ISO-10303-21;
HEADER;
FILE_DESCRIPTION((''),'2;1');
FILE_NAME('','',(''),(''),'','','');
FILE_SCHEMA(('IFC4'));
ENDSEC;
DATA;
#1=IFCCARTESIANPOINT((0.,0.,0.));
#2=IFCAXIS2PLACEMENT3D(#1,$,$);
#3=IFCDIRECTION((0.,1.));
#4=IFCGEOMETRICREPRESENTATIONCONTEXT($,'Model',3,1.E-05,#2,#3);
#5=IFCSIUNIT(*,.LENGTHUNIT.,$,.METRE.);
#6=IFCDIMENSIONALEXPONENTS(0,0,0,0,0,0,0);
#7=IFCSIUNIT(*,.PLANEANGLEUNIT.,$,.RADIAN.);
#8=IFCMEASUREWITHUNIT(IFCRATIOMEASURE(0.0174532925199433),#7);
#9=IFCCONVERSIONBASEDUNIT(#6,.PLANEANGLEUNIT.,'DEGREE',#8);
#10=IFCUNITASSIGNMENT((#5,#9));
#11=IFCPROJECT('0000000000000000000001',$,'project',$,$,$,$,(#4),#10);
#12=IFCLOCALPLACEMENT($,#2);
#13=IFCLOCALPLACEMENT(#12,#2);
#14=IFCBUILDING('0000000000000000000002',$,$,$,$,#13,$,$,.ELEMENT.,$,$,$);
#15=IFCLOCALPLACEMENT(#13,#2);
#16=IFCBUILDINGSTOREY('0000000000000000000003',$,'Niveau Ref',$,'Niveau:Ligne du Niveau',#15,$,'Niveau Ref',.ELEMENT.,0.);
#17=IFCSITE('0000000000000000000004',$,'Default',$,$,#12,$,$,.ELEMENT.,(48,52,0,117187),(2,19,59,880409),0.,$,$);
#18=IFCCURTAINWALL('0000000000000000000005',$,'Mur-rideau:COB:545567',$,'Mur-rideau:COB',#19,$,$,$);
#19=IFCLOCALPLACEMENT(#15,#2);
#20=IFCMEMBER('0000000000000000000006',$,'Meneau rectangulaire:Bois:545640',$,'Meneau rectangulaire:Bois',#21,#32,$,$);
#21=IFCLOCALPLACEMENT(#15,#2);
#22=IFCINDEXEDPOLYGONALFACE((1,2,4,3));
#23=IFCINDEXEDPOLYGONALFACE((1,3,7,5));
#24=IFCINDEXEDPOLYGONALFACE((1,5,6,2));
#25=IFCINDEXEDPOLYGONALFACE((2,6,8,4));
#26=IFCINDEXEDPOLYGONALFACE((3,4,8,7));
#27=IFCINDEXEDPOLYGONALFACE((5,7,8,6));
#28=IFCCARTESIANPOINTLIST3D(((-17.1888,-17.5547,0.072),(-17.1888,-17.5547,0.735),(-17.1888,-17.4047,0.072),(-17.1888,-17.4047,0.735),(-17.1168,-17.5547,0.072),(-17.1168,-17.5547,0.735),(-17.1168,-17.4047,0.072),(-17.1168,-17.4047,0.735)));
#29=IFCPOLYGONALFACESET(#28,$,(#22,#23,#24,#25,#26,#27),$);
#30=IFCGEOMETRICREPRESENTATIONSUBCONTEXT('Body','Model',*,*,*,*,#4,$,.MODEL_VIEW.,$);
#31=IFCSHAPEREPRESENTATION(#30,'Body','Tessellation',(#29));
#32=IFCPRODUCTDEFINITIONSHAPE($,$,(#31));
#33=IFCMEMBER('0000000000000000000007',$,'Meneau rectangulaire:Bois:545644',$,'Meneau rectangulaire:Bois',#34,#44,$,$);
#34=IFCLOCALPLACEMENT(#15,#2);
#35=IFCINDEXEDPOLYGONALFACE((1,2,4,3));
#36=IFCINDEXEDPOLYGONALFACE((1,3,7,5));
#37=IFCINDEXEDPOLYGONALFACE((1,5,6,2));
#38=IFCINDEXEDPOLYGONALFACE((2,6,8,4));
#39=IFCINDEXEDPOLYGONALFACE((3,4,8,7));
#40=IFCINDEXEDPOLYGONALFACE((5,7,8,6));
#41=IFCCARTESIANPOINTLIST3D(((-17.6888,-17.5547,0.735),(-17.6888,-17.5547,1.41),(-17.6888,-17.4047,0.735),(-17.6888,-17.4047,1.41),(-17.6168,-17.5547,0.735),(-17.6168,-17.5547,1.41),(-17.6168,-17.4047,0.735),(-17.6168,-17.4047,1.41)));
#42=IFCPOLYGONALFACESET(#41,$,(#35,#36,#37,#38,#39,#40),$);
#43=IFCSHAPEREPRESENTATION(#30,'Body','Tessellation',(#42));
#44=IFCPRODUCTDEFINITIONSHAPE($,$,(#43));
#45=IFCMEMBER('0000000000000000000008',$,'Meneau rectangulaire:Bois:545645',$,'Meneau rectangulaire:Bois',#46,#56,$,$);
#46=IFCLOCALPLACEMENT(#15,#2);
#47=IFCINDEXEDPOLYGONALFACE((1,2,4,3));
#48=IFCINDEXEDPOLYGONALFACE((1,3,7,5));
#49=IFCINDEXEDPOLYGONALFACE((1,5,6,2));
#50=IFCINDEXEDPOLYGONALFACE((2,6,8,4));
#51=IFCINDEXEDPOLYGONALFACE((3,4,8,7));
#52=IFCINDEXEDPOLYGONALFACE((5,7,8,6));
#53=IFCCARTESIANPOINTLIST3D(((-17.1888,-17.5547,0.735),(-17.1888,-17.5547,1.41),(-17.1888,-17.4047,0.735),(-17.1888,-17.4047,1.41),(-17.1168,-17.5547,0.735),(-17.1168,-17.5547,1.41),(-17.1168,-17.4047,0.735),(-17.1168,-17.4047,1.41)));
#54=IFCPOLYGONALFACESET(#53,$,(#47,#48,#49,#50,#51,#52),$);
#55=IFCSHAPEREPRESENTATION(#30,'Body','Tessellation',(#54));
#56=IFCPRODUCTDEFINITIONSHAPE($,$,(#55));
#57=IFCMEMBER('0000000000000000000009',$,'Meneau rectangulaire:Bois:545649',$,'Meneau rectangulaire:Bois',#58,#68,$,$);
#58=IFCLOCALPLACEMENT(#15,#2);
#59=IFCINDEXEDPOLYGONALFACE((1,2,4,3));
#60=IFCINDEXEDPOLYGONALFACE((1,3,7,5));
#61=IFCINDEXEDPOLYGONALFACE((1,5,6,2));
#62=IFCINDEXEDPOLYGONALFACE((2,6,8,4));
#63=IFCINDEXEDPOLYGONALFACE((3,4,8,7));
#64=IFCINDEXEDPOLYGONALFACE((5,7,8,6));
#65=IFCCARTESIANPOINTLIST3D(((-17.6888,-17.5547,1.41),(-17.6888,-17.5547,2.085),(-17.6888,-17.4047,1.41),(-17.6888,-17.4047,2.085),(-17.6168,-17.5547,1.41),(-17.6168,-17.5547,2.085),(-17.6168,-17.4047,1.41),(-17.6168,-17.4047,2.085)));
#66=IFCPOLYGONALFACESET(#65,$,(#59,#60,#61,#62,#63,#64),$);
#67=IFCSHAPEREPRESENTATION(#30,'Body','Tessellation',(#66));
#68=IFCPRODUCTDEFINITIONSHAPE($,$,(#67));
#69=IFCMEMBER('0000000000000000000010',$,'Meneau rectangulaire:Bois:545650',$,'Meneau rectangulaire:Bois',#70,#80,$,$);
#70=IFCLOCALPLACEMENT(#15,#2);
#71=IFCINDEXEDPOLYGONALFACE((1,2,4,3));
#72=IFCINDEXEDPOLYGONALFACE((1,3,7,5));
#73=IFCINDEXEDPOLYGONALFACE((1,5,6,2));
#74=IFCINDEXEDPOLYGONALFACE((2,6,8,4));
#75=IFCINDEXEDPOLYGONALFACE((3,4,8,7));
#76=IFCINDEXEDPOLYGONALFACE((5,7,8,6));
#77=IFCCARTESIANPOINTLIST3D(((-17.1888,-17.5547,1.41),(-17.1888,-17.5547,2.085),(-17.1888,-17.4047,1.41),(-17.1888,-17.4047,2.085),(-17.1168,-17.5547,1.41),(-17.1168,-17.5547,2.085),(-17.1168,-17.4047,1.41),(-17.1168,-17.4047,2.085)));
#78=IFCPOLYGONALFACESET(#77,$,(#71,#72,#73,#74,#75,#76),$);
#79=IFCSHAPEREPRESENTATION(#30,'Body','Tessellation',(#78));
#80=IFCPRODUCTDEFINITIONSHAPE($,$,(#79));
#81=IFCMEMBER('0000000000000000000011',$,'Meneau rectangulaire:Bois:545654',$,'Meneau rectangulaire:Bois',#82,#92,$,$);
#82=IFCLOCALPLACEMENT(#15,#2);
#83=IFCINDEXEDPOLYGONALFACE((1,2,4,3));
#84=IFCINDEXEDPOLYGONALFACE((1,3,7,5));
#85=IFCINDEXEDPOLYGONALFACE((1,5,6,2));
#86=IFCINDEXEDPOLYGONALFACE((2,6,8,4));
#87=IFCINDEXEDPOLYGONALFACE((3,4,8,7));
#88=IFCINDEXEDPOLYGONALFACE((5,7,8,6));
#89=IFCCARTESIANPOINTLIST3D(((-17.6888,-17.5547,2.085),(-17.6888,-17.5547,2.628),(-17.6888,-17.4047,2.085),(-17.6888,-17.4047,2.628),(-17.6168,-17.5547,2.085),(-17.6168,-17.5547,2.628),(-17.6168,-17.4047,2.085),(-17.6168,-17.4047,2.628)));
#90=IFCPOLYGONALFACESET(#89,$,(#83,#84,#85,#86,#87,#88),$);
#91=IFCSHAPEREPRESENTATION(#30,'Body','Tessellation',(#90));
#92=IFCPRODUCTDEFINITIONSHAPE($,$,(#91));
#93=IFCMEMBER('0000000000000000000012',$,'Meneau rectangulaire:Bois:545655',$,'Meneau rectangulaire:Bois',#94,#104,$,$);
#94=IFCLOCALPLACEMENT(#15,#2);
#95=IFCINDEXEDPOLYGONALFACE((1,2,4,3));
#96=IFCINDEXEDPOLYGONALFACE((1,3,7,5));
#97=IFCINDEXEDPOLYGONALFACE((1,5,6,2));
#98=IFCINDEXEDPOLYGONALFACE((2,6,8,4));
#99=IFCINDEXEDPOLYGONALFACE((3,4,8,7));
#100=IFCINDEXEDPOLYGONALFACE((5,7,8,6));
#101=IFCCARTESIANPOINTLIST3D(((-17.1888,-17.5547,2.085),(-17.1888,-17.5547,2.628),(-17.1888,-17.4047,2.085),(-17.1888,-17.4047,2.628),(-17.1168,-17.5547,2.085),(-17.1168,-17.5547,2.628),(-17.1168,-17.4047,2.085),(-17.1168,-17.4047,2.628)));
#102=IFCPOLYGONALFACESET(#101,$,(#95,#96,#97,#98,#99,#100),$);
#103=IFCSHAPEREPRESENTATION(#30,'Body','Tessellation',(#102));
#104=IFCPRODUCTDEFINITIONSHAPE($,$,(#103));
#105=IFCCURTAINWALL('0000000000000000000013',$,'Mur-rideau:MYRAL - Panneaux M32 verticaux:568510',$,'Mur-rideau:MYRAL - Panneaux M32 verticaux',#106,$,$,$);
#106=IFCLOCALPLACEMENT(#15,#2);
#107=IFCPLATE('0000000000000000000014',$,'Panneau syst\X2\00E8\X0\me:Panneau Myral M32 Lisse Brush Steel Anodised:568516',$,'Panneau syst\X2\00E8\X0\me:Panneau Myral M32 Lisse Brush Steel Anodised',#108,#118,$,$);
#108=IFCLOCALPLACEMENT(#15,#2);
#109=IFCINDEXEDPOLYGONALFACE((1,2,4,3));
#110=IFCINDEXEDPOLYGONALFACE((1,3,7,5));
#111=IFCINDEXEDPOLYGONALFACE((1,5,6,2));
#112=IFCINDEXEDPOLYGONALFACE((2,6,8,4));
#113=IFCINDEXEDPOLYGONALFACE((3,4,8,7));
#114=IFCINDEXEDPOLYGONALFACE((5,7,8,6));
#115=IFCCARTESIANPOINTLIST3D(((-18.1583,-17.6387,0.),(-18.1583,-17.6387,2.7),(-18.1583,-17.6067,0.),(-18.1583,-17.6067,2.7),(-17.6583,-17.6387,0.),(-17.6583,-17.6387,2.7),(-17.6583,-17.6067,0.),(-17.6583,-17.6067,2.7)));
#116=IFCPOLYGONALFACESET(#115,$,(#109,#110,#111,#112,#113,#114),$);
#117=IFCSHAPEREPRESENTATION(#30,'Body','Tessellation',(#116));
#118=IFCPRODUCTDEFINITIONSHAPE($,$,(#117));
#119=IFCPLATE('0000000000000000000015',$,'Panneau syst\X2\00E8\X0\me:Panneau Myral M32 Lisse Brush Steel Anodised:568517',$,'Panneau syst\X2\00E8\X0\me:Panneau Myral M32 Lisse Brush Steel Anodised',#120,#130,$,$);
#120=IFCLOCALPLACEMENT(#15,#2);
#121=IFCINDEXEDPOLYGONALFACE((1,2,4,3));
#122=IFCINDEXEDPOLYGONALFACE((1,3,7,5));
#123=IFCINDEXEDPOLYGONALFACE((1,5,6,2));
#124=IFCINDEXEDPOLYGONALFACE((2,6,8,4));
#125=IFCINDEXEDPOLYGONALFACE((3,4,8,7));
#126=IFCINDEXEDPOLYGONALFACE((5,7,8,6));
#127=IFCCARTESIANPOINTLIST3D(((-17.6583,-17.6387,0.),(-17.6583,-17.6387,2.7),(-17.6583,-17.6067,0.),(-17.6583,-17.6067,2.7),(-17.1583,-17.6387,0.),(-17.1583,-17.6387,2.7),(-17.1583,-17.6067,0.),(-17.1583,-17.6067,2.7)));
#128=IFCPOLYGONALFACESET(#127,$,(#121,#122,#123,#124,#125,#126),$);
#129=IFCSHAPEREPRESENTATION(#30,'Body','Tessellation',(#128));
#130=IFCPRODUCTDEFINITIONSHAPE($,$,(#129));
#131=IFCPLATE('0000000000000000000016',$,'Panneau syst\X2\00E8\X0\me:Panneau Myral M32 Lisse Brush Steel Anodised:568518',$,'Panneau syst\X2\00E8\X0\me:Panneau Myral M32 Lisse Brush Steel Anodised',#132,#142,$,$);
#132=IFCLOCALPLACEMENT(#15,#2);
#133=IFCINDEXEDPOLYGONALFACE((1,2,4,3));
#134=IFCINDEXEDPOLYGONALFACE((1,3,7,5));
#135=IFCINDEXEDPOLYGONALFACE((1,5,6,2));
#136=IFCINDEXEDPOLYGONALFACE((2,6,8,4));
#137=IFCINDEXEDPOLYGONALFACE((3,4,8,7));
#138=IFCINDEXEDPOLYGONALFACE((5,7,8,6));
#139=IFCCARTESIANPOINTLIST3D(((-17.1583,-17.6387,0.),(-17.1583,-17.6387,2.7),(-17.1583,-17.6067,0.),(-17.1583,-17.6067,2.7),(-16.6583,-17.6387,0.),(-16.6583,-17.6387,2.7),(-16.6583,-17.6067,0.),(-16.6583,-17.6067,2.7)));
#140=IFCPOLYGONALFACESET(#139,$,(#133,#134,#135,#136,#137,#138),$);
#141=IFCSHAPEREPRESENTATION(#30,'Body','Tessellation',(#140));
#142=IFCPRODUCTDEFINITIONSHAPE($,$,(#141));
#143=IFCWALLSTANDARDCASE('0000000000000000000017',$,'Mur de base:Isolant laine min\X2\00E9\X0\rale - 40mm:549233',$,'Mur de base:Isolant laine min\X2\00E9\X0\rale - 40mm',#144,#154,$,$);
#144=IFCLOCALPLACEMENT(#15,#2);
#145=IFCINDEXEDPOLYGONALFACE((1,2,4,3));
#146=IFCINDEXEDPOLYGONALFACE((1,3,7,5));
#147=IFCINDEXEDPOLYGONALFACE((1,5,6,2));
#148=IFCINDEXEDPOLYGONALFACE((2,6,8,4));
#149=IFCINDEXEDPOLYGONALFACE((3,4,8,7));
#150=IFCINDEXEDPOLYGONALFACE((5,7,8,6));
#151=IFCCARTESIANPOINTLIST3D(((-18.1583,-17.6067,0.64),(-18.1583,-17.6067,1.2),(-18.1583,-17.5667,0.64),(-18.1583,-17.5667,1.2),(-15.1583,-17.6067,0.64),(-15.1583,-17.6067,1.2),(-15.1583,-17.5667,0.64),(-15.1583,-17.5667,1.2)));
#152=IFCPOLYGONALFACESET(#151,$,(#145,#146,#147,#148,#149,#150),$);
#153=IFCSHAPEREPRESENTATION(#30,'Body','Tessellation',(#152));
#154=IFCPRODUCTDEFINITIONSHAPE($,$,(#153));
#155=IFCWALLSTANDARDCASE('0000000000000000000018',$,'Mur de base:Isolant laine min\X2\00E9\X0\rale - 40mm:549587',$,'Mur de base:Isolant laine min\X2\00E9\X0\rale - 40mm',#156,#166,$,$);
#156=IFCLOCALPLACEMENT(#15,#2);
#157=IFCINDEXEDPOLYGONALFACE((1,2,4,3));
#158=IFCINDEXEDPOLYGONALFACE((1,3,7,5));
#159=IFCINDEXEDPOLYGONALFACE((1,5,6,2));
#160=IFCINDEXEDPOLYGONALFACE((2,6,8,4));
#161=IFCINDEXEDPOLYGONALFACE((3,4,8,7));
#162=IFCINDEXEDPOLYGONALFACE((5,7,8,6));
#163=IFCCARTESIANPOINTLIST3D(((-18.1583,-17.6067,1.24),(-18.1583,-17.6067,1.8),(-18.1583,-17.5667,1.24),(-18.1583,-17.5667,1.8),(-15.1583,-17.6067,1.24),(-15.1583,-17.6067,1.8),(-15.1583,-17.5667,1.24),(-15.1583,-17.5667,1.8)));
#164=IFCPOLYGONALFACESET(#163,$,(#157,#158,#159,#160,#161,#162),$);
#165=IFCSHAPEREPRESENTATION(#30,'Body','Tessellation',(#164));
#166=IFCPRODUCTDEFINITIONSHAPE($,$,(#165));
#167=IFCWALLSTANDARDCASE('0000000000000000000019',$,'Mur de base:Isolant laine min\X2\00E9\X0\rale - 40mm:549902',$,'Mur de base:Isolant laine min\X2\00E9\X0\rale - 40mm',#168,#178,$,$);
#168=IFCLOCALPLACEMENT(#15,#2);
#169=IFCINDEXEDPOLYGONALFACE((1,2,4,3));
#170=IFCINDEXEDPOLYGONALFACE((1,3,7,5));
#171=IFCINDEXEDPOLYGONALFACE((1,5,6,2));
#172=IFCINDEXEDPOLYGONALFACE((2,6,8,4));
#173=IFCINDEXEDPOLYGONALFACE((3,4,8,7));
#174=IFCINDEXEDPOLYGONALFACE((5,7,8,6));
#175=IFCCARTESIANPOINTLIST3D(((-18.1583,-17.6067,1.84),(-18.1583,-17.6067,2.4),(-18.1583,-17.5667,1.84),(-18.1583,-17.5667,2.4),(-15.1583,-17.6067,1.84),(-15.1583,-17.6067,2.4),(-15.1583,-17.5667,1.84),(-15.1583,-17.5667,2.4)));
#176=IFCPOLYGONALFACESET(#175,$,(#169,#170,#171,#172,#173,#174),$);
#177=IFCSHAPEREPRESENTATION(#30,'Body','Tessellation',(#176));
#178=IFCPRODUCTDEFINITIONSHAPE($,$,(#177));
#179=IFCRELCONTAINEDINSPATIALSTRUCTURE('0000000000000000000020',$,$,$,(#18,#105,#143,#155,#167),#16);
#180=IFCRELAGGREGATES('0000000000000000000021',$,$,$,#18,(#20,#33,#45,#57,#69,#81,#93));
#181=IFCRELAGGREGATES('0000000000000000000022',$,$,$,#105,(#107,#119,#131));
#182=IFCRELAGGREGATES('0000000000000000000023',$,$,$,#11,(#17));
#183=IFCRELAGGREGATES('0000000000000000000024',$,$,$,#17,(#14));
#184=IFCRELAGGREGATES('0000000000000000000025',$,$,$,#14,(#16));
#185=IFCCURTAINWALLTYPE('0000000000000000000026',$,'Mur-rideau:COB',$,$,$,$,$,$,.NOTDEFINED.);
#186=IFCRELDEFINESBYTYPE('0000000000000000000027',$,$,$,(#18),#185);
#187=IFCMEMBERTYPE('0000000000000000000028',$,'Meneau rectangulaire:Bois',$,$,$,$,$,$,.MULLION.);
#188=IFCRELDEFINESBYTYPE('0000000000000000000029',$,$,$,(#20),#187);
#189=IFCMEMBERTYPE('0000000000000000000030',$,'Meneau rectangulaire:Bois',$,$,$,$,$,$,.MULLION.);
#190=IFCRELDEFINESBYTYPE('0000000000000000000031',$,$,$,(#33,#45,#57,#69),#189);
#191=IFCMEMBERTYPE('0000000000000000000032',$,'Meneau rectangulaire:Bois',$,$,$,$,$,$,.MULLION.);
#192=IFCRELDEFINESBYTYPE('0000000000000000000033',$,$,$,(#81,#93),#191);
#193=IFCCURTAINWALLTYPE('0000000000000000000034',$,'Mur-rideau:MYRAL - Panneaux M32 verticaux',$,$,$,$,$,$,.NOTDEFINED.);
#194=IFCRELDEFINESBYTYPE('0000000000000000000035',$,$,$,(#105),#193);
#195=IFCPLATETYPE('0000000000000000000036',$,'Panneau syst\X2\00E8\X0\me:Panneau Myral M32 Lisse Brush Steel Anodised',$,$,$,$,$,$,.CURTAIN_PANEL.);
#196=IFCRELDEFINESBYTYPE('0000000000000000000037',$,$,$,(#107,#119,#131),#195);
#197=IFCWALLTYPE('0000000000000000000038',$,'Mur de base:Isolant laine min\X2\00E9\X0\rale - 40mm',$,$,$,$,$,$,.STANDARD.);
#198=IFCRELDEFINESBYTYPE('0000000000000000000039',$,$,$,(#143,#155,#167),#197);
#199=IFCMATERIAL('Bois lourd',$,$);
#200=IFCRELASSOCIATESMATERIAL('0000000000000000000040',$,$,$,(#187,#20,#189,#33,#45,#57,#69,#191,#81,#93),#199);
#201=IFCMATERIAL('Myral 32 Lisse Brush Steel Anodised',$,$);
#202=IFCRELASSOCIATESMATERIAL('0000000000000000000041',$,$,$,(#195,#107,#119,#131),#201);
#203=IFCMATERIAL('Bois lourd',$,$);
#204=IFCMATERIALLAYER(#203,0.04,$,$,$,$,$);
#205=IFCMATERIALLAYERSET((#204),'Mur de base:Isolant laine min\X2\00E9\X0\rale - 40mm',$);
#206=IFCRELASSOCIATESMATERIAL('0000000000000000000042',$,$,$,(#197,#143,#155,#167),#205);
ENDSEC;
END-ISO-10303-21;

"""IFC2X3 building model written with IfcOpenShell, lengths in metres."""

from ifc_helpers import new_model, entity, si_unit, converted_unit, direction, frame, frame_2d, origin, origin_2d_with_axis, place, context, subcontext, project, spatial, rectangle, extrude, source, transform, mapped, material, layer, layer_set, layer_usage, type_object, type_shapes, element, aggregate, save


model = new_model("IFC2X3")

# Units and contexts
model_context = context("Model", 3, precision=1e-05, world=origin(), true_north=direction((0.0, 1.0)))
body_context = subcontext(model_context, "Body", "Model", "MODEL_VIEW")
ifc_project = project(units=[si_unit("LENGTHUNIT", "METRE"), converted_unit("PLANEANGLEUNIT", "DEGREE", entity("IfcRatioMeasure", 0.0174532925199433), si_unit("PLANEANGLEUNIT", "RADIAN"), dimensions=[0, 0, 0, 0, 0, 0, 0])], contexts=[model_context])

# Site, building, storey
site_placement = place(None, origin())
site = spatial("IfcSite", under=ifc_project, at=site_placement, Name="Default", CompositionType="ELEMENT", RefLatitude=(48, 52, 0, 117187), RefLongitude=(2, 19, 59, 880409), RefElevation=0.0)
building_placement = place(site_placement, origin())
building = spatial("IfcBuilding", under=site, at=building_placement, CompositionType="ELEMENT")
storey_placement = place(building_placement, origin())
storey = spatial("IfcBuildingStorey", under=building, at=storey_placement, Name="Niveau Ref", ObjectType="Niveau:Ligne du Niveau", LongName="Niveau Ref", CompositionType="ELEMENT", Elevation=0.0)

# Curtain wall, members
curtain_wall_type_1 = type_object("IfcCurtainWallType", Name="Mur-rideau:COB", PredefinedType="NOTDEFINED")
curtain_wall_1_placement = place(storey_placement, origin())
curtain_wall_1 = element("IfcCurtainWall", 1, at=curtain_wall_1_placement, inside=storey, type_object=curtain_wall_type_1, Name="Mur-rideau:COB:545567", ObjectType="Mur-rideau:COB")
ifc_material_1 = material(Name="Bois lourd")
member_type_1 = type_object("IfcMemberType", Name="Meneau rectangulaire:Bois", PredefinedType="MULLION", material=ifc_material_1)
shared_shape_1 = source(origin(), body_context, "Body", "SweptSolid", [
    extrude(rectangle(XDim=0.15, YDim=0.072, at=origin_2d_with_axis()), frame((-0.024, 0.0, -0.663), z_axis=(0.0, 0.0, 1.0), x_axis=(0.0, -1.0, 0.0)), (0.0, 0.0, 1.0), 0.663),
])
type_shapes(member_type_1, [shared_shape_1])
member_1_placement = place(storey_placement, frame((-17.1288, -17.4797, 0.072), z_axis=(0.0, 0.0, -1.0), x_axis=(1.0, 0.0, 0.0)))
member_1 = element("IfcMember", 2, at=member_1_placement, type_object=member_type_1, material=ifc_material_1, Name="Meneau rectangulaire:Bois:545640", ObjectType="Meneau rectangulaire:Bois", context=body_context, shape_type="MappedRepresentation", body=[
    mapped(shared_shape_1, transform((0.0, 0.0, 0.0), scale=1.0)),
])
member_type_2 = type_object("IfcMemberType", Name="Meneau rectangulaire:Bois", PredefinedType="MULLION", material=ifc_material_1)
shared_shape_2 = source(origin(), body_context, "Body", "SweptSolid", [
    extrude(rectangle(XDim=0.15, YDim=0.072, at=origin_2d_with_axis()), frame((-0.024, 0.0, -0.675), z_axis=(0.0, 0.0, 1.0), x_axis=(0.0, -1.0, 0.0)), (0.0, 0.0, 1.0), 0.675),
])
type_shapes(member_type_2, [shared_shape_2])
member_2_placement = place(storey_placement, frame((-17.6288, -17.4797, 0.735), z_axis=(0.0, 0.0, -1.0), x_axis=(1.0, 0.0, 0.0)))
member_2 = element("IfcMember", 3, at=member_2_placement, type_object=member_type_2, material=ifc_material_1, Name="Meneau rectangulaire:Bois:545644", ObjectType="Meneau rectangulaire:Bois", context=body_context, shape_type="MappedRepresentation", body=[
    mapped(shared_shape_2, transform((0.0, 0.0, 0.0), scale=1.0)),
])
member_3_placement = place(storey_placement, frame((-17.1288, -17.4797, 0.735), z_axis=(0.0, 0.0, -1.0), x_axis=(1.0, 0.0, 0.0)))
member_3 = element("IfcMember", 4, at=member_3_placement, type_object=member_type_2, material=ifc_material_1, Name="Meneau rectangulaire:Bois:545645", ObjectType="Meneau rectangulaire:Bois", context=body_context, shape_type="MappedRepresentation", body=[
    mapped(shared_shape_2, transform((0.0, 0.0, 0.0), scale=1.0)),
])
member_4_placement = place(storey_placement, frame((-17.6288, -17.4797, 1.41), z_axis=(0.0, 0.0, -1.0), x_axis=(1.0, 0.0, 0.0)))
member_4 = element("IfcMember", 5, at=member_4_placement, type_object=member_type_2, material=ifc_material_1, Name="Meneau rectangulaire:Bois:545649", ObjectType="Meneau rectangulaire:Bois", context=body_context, shape_type="MappedRepresentation", body=[
    mapped(shared_shape_2, transform((0.0, 0.0, 0.0), scale=1.0)),
])
member_5_placement = place(storey_placement, frame((-17.1288, -17.4797, 1.41), z_axis=(0.0, 0.0, -1.0), x_axis=(1.0, 0.0, 0.0)))
member_5 = element("IfcMember", 6, at=member_5_placement, type_object=member_type_2, material=ifc_material_1, Name="Meneau rectangulaire:Bois:545650", ObjectType="Meneau rectangulaire:Bois", context=body_context, shape_type="MappedRepresentation", body=[
    mapped(shared_shape_2, transform((0.0, 0.0, 0.0), scale=1.0)),
])
member_type_3 = type_object("IfcMemberType", Name="Meneau rectangulaire:Bois", PredefinedType="MULLION", material=ifc_material_1)
shared_shape_3 = source(origin(), body_context, "Body", "SweptSolid", [
    extrude(rectangle(XDim=0.15, YDim=0.072, at=origin_2d_with_axis()), frame((-0.024, 0.0, -0.543), z_axis=(0.0, 0.0, 1.0), x_axis=(0.0, -1.0, 0.0)), (0.0, 0.0, 1.0), 0.543),
])
type_shapes(member_type_3, [shared_shape_3])
member_6_placement = place(storey_placement, frame((-17.6288, -17.4797, 2.085), z_axis=(0.0, 0.0, -1.0), x_axis=(1.0, 0.0, 0.0)))
member_6 = element("IfcMember", 7, at=member_6_placement, type_object=member_type_3, material=ifc_material_1, Name="Meneau rectangulaire:Bois:545654", ObjectType="Meneau rectangulaire:Bois", context=body_context, shape_type="MappedRepresentation", body=[
    mapped(shared_shape_3, transform((0.0, 0.0, 0.0), scale=1.0)),
])
member_7_placement = place(storey_placement, frame((-17.1288, -17.4797, 2.085), z_axis=(0.0, 0.0, -1.0), x_axis=(1.0, 0.0, 0.0)))
member_7 = element("IfcMember", 8, at=member_7_placement, type_object=member_type_3, material=ifc_material_1, Name="Meneau rectangulaire:Bois:545655", ObjectType="Meneau rectangulaire:Bois", context=body_context, shape_type="MappedRepresentation", body=[
    mapped(shared_shape_3, transform((0.0, 0.0, 0.0), scale=1.0)),
])
aggregate(curtain_wall_1, [member_1, member_2, member_3, member_4, member_5, member_6, member_7])

# Curtain wall, plates
curtain_wall_type_2 = type_object("IfcCurtainWallType", Name="Mur-rideau:MYRAL - Panneaux M32 verticaux", PredefinedType="NOTDEFINED")
curtain_wall_2_placement = place(storey_placement, origin())
curtain_wall_2 = element("IfcCurtainWall", 9, at=curtain_wall_2_placement, inside=storey, type_object=curtain_wall_type_2, Name="Mur-rideau:MYRAL - Panneaux M32 verticaux:568510", ObjectType="Mur-rideau:MYRAL - Panneaux M32 verticaux")
ifc_material_2 = material(Name="Myral 32 Lisse Brush Steel Anodised")
plate_type = type_object("IfcPlateType", Name="Panneau système:Panneau Myral M32 Lisse Brush Steel Anodised", PredefinedType="CURTAIN_PANEL", material=ifc_material_2)
shared_shape_4 = source(origin(), body_context, "Body", "SweptSolid", [
    extrude(rectangle(XDim=0.032, YDim=0.5, at=origin_2d_with_axis()), frame((0.0, -0.016, 0.0), z_axis=(0.0, 0.0, 1.0), x_axis=(0.0, 1.0, 0.0)), (0.0, 0.0, 1.0), 2.7),
])
type_shapes(plate_type, [shared_shape_4])
plate_1_placement = place(curtain_wall_2_placement, frame((-17.9083, -17.6067, 0.0)))
plate_1 = element("IfcPlate", 10, at=plate_1_placement, type_object=plate_type, material=ifc_material_2, Name="Panneau système:Panneau Myral M32 Lisse Brush Steel Anodised:568516", ObjectType="Panneau système:Panneau Myral M32 Lisse Brush Steel Anodised", context=body_context, shape_type="MappedRepresentation", body=[
    mapped(shared_shape_4, transform((0.0, 0.0, 0.0), scale=1.0)),
])
plate_2_placement = place(curtain_wall_2_placement, frame((-17.4083, -17.6067, 0.0)))
plate_2 = element("IfcPlate", 11, at=plate_2_placement, type_object=plate_type, material=ifc_material_2, Name="Panneau système:Panneau Myral M32 Lisse Brush Steel Anodised:568517", ObjectType="Panneau système:Panneau Myral M32 Lisse Brush Steel Anodised", context=body_context, shape_type="MappedRepresentation", body=[
    mapped(shared_shape_4, transform((0.0, 0.0, 0.0), scale=1.0)),
])
plate_3_placement = place(curtain_wall_2_placement, frame((-16.9083, -17.6067, 0.0)))
plate_3 = element("IfcPlate", 12, at=plate_3_placement, type_object=plate_type, material=ifc_material_2, Name="Panneau système:Panneau Myral M32 Lisse Brush Steel Anodised:568518", ObjectType="Panneau système:Panneau Myral M32 Lisse Brush Steel Anodised", context=body_context, shape_type="MappedRepresentation", body=[
    mapped(shared_shape_4, transform((0.0, 0.0, 0.0), scale=1.0)),
])
aggregate(curtain_wall_2, [plate_1, plate_2, plate_3])

# Walls
ifc_material_3 = material(Name="Bois lourd")
ifc_layer = layer(ifc_material_3, 0.04)
ifc_layer_set = layer_set([ifc_layer], Name="Mur de base:Isolant laine minérale - 40mm")
ifc_layer_usage_1 = layer_usage(ifc_layer_set, "AXIS2", "NEGATIVE", 0.02)
wall_type = type_object("IfcWallType", Name="Mur de base:Isolant laine minérale - 40mm", PredefinedType="STANDARD", material=ifc_layer_set)
wall_1_placement = place(storey_placement, frame((-18.1583, -17.5867, 0.64)))
element("IfcWallStandardCase", 13, at=wall_1_placement, inside=storey, type_object=wall_type, material=ifc_layer_usage_1, Name="Mur de base:Isolant laine minérale - 40mm:549233", ObjectType="Mur de base:Isolant laine minérale - 40mm", context=body_context, shape_type="SweptSolid", body=[
    extrude(rectangle(XDim=3.0, YDim=0.04, at=frame_2d((1.5, 0.0), x_axis=(-1.0, 0.0))), origin(), (0.0, 0.0, 1.0), 0.56),
])
ifc_layer_usage_2 = layer_usage(ifc_layer_set, "AXIS2", "NEGATIVE", 0.02)
wall_2_placement = place(storey_placement, frame((-18.1583, -17.5867, 1.24)))
element("IfcWallStandardCase", 14, at=wall_2_placement, inside=storey, type_object=wall_type, material=ifc_layer_usage_2, Name="Mur de base:Isolant laine minérale - 40mm:549587", ObjectType="Mur de base:Isolant laine minérale - 40mm", context=body_context, shape_type="SweptSolid", body=[
    extrude(rectangle(XDim=3.0, YDim=0.04, at=frame_2d((1.5, 0.0), x_axis=(-1.0, 0.0))), origin(), (0.0, 0.0, 1.0), 0.56),
])
ifc_layer_usage_3 = layer_usage(ifc_layer_set, "AXIS2", "NEGATIVE", 0.02)
wall_3_placement = place(storey_placement, frame((-18.1583, -17.5867, 1.84)))
element("IfcWallStandardCase", 15, at=wall_3_placement, inside=storey, type_object=wall_type, material=ifc_layer_usage_3, Name="Mur de base:Isolant laine minérale - 40mm:549902", ObjectType="Mur de base:Isolant laine minérale - 40mm", context=body_context, shape_type="SweptSolid", body=[
    extrude(rectangle(XDim=3.0, YDim=0.04, at=frame_2d((1.5, 0.0), x_axis=(-1.0, 0.0))), origin(), (0.0, 0.0, 1.0), 0.56),
])

save(model, "model.ifc")
